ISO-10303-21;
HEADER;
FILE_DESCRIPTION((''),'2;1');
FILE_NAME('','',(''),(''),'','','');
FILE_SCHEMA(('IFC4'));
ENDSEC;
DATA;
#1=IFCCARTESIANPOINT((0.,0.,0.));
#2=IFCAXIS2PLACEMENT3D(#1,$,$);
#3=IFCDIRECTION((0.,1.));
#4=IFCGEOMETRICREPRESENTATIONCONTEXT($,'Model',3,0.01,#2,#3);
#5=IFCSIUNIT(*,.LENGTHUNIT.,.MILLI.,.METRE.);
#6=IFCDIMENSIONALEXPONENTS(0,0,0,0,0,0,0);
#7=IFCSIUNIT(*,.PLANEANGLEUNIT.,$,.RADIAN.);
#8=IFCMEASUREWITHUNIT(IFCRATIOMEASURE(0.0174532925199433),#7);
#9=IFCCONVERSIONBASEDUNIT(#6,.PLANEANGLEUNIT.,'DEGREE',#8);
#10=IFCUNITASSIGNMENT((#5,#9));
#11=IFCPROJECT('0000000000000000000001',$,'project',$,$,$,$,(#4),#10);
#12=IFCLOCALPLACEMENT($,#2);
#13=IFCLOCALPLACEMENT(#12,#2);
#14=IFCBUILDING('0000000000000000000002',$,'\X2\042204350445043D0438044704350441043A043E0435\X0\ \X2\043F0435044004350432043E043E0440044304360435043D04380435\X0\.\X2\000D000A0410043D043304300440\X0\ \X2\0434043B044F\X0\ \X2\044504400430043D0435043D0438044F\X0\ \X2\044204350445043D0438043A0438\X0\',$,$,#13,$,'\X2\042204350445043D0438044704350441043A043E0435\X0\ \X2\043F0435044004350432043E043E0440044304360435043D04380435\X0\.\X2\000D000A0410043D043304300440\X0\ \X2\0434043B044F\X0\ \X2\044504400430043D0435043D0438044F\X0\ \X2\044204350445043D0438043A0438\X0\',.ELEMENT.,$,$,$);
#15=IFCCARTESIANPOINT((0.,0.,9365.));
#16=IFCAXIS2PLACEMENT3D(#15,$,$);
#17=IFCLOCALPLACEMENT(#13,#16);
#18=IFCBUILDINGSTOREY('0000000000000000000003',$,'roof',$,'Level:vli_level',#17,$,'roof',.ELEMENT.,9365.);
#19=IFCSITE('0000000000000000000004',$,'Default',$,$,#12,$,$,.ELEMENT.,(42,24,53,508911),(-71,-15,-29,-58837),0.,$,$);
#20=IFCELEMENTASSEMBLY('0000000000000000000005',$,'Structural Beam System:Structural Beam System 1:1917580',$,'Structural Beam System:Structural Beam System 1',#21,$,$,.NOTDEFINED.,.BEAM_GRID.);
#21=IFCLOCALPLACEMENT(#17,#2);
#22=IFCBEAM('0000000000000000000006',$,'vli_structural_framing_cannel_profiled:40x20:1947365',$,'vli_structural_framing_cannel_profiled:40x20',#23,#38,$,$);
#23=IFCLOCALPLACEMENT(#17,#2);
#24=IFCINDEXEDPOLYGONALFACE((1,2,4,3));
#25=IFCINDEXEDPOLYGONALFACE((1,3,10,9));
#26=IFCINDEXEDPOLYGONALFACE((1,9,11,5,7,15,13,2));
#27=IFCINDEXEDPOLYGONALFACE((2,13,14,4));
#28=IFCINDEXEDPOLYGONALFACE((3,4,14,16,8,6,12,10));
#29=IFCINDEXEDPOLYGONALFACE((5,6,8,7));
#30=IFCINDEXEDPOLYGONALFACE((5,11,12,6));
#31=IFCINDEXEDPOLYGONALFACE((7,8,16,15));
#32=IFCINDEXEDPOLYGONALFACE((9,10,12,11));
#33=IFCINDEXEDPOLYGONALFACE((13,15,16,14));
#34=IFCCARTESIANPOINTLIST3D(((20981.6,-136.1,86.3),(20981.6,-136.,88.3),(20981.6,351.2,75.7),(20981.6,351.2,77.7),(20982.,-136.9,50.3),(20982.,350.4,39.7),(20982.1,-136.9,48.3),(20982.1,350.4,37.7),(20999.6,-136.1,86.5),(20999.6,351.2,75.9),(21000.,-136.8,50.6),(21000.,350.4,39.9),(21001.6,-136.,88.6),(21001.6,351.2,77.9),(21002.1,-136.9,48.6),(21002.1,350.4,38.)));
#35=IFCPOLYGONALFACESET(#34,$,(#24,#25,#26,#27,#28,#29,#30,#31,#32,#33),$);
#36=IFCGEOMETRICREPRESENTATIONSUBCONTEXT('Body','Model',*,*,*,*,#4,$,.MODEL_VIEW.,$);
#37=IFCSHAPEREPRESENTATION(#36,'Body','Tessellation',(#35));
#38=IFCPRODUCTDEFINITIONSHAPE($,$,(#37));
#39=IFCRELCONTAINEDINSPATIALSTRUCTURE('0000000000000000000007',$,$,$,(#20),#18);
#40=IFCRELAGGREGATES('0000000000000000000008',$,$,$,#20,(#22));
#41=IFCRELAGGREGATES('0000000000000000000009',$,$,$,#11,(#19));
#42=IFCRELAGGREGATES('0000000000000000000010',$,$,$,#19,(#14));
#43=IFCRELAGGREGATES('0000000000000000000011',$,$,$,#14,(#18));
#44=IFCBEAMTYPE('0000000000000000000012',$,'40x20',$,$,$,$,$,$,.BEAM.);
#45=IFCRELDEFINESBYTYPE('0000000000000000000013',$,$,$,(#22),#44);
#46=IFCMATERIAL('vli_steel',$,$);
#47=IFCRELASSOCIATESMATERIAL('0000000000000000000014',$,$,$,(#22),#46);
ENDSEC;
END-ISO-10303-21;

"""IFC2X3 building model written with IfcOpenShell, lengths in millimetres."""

from ifc_helpers import new_model, entity, si_unit, converted_unit, direction, frame, origin, place, context, subcontext, project, spatial, polyline, outline, extrude, material, type_object, element, aggregate, save


model = new_model("IFC2X3")

# Units and contexts
model_context = context("Model", 3, precision=0.01, world=origin(), true_north=direction((0.0, 1.0)))
body_context = subcontext(model_context, "Body", "Model", "MODEL_VIEW")
ifc_project = project(units=[si_unit("LENGTHUNIT", "METRE", prefix="MILLI"), converted_unit("PLANEANGLEUNIT", "DEGREE", entity("IfcRatioMeasure", 0.0174532925199433), si_unit("PLANEANGLEUNIT", "RADIAN"), dimensions=[0, 0, 0, 0, 0, 0, 0])], contexts=[model_context])

# Site, building, storey
site_placement = place(None, origin())
site = spatial("IfcSite", under=ifc_project, at=site_placement, Name="Default", CompositionType="ELEMENT", RefLatitude=(42, 24, 53, 508911), RefLongitude=(-71, -15, -29, -58837), RefElevation=0.0)
building_placement = place(site_placement, origin())
building = spatial("IfcBuilding", under=site, at=building_placement, Name="Техническое перевооружение.\r\nАнгар для хранения техники", LongName="Техническое перевооружение.\r\nАнгар для хранения техники", CompositionType="ELEMENT")
storey_placement = place(building_placement, frame((0.0, 0.0, 9365.0)))
storey = spatial("IfcBuildingStorey", under=building, at=storey_placement, Name="roof", ObjectType="Level:vli_level", LongName="roof", CompositionType="ELEMENT", Elevation=9365.0)

# Shared definitions
ifc_material = material(Name="vli_steel")
beam_type = type_object("IfcBeamType", Name="40x20", PredefinedType="BEAM")

# Element assembly, beam
assembly_1_placement = place(storey_placement, origin())
assembly_1 = element("IfcElementAssembly", 1, at=assembly_1_placement, inside=storey, Name="Structural Beam System:Structural Beam System 1:1917580", ObjectType="Structural Beam System:Structural Beam System 1", AssemblyPlace="NOTDEFINED", PredefinedType="BEAM_GRID")
beam_1_placement = place(assembly_1_placement, frame((21001.0, 366.5, 77.6), z_axis=(0.0, 0.02179, 0.999763), x_axis=(0.0, -0.999763, 0.02179)))
beam_1 = element("IfcBeam", 2, at=beam_1_placement, type_object=beam_type, material=ifc_material, Name="vli_structural_framing_cannel_profiled:40x20:1947365", ObjectType="vli_structural_framing_cannel_profiled:40x20", context=body_context, shape_type="SweptSolid", body=[
    extrude(outline(polyline([(-10.5, -20.0), (9.5, -20.0), (9.5, -18.0), (-8.5, -18.0), (-8.5, 18.0), (9.5, 18.0), (9.5, 20.0), (-10.5, 20.0), (-10.5, -20.0)])), frame((15.3, -9.7, -20.1), z_axis=(1.0, 0.0, 0.0), x_axis=(0.0, -0.999925, -0.012243)), (0.0, 0.0, 1.0), 487.4),
])
aggregate(assembly_1, [beam_1])

save(model, "model.ifc")
